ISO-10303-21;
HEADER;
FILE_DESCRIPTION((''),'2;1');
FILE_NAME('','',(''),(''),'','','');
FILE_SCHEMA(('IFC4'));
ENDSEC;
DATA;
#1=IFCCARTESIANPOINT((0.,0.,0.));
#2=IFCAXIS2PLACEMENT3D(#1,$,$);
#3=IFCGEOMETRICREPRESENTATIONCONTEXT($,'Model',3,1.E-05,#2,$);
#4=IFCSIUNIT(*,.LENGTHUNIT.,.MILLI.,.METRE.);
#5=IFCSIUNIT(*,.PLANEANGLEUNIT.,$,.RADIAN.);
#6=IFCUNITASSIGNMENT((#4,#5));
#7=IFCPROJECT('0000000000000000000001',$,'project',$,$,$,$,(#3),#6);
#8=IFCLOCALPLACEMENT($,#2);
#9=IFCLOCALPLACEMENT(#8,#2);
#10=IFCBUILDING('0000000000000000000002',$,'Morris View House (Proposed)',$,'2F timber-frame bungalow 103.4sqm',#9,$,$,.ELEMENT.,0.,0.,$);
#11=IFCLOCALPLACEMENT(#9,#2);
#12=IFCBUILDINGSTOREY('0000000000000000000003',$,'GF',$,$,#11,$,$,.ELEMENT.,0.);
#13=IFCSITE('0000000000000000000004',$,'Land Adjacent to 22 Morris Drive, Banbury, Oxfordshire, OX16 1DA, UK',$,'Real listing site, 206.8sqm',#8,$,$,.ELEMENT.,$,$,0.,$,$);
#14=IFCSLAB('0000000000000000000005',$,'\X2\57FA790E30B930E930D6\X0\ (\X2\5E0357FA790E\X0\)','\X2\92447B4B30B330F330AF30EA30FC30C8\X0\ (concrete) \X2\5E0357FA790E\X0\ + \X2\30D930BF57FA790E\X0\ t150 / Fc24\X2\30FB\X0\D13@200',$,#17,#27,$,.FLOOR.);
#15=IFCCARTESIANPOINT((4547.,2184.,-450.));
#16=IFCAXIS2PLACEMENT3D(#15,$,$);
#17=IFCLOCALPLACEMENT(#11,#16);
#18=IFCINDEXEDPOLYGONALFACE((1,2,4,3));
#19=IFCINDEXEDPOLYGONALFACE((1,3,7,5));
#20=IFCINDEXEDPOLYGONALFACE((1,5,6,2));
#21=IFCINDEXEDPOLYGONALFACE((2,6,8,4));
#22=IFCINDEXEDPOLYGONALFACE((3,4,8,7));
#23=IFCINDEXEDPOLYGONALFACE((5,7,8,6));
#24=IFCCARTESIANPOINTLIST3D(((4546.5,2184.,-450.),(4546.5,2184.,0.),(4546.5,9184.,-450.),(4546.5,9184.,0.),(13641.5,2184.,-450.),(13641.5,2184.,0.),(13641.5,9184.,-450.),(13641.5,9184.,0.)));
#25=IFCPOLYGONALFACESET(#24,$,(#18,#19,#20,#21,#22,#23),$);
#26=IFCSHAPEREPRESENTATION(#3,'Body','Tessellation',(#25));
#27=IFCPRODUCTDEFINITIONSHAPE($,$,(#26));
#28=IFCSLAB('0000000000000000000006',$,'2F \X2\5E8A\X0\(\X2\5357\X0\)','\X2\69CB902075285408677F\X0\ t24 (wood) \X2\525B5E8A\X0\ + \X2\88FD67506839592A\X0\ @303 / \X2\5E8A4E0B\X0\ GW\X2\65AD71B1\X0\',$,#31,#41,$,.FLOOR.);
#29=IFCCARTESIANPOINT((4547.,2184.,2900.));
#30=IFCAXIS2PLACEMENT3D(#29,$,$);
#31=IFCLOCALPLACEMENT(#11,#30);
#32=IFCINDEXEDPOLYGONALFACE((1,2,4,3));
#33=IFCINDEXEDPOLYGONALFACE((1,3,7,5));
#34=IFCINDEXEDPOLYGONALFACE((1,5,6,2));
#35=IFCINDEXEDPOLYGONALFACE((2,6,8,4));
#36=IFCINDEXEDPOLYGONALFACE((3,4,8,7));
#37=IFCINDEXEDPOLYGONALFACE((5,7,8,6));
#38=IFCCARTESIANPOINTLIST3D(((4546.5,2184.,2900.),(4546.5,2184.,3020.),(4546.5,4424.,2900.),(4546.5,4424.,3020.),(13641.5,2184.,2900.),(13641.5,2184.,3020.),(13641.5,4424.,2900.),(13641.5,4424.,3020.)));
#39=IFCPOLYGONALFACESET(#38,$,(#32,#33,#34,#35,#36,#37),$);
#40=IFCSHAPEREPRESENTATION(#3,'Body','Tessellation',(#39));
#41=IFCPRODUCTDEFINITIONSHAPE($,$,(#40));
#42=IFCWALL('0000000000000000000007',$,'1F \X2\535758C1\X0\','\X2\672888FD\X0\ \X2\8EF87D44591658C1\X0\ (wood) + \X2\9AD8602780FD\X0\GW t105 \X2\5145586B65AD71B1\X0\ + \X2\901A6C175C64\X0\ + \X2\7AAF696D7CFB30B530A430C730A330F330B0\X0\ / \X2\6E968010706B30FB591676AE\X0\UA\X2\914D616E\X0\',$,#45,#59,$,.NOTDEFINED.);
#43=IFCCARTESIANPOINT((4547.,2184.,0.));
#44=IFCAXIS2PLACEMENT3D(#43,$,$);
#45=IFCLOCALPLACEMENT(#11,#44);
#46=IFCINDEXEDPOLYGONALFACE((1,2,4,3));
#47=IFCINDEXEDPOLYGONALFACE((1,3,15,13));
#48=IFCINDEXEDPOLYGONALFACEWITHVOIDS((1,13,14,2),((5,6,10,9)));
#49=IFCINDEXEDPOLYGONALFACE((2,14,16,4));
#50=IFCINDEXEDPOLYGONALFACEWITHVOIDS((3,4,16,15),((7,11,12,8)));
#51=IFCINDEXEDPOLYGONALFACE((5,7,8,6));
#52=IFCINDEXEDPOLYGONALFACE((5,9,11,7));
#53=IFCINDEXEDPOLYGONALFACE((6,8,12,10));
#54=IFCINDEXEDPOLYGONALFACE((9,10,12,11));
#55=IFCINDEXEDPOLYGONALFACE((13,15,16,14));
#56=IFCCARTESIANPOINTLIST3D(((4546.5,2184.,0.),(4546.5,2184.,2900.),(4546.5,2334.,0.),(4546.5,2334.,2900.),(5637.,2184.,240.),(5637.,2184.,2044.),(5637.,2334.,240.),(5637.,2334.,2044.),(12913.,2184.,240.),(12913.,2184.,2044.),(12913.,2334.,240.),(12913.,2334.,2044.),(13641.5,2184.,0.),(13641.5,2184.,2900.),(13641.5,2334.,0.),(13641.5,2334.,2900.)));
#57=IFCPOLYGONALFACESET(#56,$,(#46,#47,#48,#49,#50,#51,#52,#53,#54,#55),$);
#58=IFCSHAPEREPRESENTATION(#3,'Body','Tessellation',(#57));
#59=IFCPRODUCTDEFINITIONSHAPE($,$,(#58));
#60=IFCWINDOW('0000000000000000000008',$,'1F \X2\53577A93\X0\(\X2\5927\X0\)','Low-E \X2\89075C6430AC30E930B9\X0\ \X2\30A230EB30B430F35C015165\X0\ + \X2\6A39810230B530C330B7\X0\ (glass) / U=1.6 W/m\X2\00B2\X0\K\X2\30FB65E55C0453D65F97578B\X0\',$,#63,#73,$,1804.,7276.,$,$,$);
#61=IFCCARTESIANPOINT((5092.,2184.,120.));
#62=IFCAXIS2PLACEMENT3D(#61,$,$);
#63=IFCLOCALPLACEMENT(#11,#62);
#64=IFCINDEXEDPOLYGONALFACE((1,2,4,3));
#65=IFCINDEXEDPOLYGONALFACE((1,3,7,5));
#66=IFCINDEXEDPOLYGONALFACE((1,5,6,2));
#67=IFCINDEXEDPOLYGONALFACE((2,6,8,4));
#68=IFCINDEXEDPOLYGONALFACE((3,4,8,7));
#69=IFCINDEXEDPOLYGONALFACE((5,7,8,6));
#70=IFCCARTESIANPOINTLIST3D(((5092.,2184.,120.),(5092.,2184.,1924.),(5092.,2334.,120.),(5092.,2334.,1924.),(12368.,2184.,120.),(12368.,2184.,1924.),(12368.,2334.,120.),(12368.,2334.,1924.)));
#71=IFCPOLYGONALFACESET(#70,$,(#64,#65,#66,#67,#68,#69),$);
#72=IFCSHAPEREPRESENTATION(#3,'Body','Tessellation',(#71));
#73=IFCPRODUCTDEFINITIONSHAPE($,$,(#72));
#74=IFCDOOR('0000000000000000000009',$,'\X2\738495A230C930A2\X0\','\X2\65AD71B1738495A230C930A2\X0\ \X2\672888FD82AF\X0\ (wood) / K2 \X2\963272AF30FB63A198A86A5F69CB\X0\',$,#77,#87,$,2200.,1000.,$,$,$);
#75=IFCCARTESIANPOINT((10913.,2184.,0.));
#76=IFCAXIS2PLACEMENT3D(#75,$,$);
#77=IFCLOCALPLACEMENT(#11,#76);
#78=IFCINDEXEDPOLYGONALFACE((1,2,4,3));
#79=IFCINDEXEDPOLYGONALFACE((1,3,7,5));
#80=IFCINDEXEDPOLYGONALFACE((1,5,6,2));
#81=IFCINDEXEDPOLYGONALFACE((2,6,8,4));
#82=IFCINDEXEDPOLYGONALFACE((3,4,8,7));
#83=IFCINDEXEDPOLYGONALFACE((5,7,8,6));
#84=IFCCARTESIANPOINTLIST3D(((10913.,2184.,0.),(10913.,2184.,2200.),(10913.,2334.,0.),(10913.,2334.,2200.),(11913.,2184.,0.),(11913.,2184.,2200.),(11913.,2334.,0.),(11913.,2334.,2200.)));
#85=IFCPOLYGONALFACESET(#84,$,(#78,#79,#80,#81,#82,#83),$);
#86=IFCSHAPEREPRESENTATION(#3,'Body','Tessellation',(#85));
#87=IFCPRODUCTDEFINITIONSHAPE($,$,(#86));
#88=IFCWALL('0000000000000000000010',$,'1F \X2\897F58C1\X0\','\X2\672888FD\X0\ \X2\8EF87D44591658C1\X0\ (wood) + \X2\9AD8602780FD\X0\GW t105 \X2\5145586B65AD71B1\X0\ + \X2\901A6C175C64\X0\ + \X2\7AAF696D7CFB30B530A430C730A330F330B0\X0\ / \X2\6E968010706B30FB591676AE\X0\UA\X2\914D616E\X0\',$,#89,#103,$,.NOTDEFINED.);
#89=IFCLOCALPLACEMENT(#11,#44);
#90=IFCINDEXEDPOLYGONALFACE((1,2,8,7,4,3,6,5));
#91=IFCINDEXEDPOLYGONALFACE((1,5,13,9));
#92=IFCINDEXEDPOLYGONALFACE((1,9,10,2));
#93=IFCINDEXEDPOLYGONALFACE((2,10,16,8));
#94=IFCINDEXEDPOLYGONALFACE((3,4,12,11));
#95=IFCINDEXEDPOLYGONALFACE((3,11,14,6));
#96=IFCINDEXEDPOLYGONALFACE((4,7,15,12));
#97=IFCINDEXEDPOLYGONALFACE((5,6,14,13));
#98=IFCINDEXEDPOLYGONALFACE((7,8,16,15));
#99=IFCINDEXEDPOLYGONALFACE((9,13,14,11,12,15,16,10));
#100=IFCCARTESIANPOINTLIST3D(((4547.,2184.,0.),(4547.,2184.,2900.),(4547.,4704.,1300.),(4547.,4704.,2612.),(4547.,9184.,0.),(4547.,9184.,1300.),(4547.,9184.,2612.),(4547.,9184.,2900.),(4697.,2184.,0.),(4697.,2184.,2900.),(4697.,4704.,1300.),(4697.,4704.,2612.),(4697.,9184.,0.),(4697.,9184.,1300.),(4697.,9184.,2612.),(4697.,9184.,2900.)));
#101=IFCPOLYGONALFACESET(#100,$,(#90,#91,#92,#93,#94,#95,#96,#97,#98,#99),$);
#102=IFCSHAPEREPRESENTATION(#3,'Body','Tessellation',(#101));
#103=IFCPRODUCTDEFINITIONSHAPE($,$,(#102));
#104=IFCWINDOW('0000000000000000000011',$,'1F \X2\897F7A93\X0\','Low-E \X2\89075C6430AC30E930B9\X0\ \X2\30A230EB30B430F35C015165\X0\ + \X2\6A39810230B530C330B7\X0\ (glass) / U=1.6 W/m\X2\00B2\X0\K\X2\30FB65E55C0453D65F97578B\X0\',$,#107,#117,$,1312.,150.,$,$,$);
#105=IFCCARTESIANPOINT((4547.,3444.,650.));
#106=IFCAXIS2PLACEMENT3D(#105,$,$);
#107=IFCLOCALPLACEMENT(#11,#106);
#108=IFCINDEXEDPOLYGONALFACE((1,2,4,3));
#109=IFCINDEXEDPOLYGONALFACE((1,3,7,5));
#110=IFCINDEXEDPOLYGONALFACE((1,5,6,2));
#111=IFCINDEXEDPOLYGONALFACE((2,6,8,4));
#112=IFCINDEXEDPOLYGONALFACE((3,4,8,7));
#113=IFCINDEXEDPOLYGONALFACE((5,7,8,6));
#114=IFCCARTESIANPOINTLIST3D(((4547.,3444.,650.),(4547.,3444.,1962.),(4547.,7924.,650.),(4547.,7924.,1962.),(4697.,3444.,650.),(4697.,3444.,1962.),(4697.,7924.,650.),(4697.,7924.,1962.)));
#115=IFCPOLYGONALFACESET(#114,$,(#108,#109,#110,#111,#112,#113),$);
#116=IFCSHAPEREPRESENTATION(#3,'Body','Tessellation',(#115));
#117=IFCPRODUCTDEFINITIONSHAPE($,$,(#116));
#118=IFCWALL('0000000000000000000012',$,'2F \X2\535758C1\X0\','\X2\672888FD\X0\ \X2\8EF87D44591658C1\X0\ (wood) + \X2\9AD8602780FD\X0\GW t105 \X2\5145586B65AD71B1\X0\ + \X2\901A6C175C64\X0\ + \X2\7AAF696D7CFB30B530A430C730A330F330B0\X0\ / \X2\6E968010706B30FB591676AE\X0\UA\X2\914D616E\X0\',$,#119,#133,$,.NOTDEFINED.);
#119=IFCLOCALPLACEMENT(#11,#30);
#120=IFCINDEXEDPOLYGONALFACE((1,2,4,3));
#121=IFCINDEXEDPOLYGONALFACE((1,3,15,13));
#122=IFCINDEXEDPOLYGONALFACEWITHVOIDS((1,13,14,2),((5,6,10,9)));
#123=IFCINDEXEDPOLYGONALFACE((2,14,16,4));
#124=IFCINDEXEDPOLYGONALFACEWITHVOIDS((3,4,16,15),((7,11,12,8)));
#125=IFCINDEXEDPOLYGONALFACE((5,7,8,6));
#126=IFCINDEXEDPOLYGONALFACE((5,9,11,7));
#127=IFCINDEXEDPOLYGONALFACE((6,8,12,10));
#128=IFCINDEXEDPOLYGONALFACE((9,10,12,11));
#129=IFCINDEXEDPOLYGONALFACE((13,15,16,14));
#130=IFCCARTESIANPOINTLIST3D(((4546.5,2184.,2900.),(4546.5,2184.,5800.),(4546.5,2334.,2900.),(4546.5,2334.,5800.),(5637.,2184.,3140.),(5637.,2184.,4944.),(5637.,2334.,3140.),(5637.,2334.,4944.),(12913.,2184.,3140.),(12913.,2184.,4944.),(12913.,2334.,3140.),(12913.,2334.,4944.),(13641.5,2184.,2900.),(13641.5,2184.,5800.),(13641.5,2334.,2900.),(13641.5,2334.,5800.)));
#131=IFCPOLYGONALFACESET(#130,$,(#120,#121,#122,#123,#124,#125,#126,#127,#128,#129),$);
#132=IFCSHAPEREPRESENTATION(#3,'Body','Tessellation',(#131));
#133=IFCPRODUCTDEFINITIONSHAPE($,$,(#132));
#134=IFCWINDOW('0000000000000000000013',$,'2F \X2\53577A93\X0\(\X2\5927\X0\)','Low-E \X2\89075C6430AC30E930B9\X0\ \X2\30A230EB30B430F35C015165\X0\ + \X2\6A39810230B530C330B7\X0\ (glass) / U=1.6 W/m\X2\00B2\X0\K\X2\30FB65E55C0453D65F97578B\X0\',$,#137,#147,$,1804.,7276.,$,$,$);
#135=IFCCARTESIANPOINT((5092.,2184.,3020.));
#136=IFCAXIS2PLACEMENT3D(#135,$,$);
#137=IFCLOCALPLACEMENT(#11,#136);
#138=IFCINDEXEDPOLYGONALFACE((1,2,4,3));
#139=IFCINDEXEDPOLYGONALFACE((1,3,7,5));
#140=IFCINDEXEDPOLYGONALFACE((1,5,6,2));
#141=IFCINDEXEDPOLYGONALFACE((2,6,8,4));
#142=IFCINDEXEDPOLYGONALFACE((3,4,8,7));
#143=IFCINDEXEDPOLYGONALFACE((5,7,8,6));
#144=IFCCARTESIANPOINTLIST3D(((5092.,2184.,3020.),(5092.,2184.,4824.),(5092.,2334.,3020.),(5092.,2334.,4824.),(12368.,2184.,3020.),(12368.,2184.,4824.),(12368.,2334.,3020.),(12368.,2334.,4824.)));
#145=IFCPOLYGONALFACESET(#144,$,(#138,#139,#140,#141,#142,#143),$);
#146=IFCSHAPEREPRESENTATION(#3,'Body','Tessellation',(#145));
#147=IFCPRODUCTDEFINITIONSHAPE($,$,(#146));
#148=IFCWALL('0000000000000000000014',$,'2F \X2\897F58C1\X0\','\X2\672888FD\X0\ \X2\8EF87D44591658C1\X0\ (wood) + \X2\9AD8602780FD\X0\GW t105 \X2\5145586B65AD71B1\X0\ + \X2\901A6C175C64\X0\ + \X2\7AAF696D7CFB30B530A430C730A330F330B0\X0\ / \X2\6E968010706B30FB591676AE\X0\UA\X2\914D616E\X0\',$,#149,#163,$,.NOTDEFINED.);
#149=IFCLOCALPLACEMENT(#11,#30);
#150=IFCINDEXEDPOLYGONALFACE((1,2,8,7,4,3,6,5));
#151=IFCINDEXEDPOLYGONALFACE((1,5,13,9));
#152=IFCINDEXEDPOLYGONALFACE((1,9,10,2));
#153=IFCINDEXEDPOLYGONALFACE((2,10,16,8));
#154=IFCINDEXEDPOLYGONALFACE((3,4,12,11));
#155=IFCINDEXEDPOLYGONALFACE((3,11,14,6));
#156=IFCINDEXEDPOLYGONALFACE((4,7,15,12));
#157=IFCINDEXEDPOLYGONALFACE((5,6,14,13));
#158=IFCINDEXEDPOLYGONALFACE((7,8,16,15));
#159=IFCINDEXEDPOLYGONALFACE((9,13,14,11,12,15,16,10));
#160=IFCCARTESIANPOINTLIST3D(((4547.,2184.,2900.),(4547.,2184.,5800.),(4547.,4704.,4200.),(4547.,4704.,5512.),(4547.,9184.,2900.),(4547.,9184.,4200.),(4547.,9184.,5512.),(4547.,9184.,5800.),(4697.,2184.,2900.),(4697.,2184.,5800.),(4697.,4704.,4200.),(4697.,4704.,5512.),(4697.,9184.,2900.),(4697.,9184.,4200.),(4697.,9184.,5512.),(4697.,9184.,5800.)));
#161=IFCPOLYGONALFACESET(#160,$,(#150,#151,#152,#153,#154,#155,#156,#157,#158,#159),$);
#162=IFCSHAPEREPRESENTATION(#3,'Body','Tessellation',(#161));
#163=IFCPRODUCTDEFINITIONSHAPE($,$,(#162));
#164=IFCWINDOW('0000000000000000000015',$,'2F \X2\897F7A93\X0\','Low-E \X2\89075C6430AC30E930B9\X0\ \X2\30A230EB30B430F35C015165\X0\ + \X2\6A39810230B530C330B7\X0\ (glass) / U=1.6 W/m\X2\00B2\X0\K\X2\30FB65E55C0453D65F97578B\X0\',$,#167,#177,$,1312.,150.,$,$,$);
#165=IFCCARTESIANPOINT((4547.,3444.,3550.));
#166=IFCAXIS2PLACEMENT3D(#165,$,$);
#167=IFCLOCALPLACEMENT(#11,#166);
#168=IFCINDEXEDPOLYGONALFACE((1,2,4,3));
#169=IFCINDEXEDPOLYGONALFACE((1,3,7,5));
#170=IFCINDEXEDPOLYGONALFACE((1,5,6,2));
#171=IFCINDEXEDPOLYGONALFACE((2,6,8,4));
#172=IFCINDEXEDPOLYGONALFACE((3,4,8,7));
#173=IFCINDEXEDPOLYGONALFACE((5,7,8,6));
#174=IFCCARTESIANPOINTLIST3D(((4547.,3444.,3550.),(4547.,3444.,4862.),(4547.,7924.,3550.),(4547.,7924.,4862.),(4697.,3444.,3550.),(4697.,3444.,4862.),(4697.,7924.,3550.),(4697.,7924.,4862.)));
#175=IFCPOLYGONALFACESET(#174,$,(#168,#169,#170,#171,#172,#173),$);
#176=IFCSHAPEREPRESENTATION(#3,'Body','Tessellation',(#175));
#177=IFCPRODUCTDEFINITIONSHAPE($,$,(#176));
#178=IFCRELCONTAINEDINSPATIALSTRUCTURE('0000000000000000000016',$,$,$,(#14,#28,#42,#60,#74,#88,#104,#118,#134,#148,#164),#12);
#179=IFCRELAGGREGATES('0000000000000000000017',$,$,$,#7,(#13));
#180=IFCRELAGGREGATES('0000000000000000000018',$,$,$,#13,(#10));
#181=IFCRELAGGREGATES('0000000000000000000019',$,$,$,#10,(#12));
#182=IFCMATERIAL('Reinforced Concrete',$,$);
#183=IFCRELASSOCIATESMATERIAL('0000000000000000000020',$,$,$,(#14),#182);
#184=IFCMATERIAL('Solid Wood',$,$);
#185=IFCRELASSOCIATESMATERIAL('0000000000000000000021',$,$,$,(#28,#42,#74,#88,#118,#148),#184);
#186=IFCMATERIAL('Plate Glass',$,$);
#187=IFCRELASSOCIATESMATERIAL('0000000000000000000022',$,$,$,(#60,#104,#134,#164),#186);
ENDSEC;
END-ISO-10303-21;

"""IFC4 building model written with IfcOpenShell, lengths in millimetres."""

from ifc_helpers import new_model, si_unit, frame, frame_2d, origin, place, context, project, spatial, rectangle, extrude, material, element, fill, save


model = new_model("IFC4")

# Units and contexts
model_context = context("Model", 3, precision=1e-05, world=origin())
ifc_project = project(units=[si_unit("LENGTHUNIT", "METRE", prefix="MILLI"), si_unit("PLANEANGLEUNIT", "RADIAN")], contexts=[model_context])

# Site, building, storey
site_placement = place(None, origin())
site = spatial("IfcSite", under=ifc_project, at=site_placement, Name="Land Adjacent to 22 Morris Drive, Banbury, Oxfordshire, OX16 1DA, UK", ObjectType="Real listing site, 206.8sqm", CompositionType="ELEMENT", RefElevation=0.0)
building_placement = place(site_placement, origin())
building = spatial("IfcBuilding", under=site, at=building_placement, Name="Morris View House (Proposed)", ObjectType="2F timber-frame bungalow 103.4sqm", CompositionType="ELEMENT", ElevationOfRefHeight=0.0, ElevationOfTerrain=0.0)
storey_placement = place(building_placement, origin())
storey = spatial("IfcBuildingStorey", under=building, at=storey_placement, Name="GF", CompositionType="ELEMENT", Elevation=0.0)

# Slabs
ifc_material_1 = material(Name="Reinforced Concrete")
slab_1_placement = place(storey_placement, frame((4547.0, 2184.0, -450.0)))
element("IfcSlab", 1, at=slab_1_placement, inside=storey, material=ifc_material_1, Name="基礎スラブ (布基礎)", Description="鉄筋コンクリート (concrete) 布基礎 + ベタ基礎 t150 / Fc24・D13@200", PredefinedType="FLOOR", context=model_context, shape_type="SweptSolid", body=[
    extrude(rectangle(XDim=9095.0, YDim=7000.0, at=frame_2d((4547.0, 3500.0))), frame((4547.0, 2184.0, -450.0)), (0.0, 0.0, 1.0), 450.0),
])
ifc_material_2 = material(Name="Solid Wood")
slab_2_placement = place(storey_placement, frame((4547.0, 2184.0, 2900.0)))
element("IfcSlab", 2, at=slab_2_placement, inside=storey, material=ifc_material_2, Name="2F 床(南)", Description="構造用合板 t24 (wood) 剛床 + 製材根太 @303 / 床下 GW断熱", PredefinedType="FLOOR", context=model_context, shape_type="SweptSolid", body=[
    extrude(rectangle(XDim=9095.0, YDim=2240.0, at=frame_2d((4547.0, 1120.0))), frame((4547.0, 2184.0, 2900.0)), (0.0, 0.0, 1.0), 120.0),
])

# Wall, openings, window, door
wall_1_placement = place(storey_placement, frame((4547.0, 2184.0, 0.0)))
wall_1 = element("IfcWall", 3, at=wall_1_placement, inside=storey, material=ifc_material_2, Name="1F 南壁", Description="木製 軸組外壁 (wood) + 高性能GW t105 充填断熱 + 通気層 + 窯業系サイディング / 準耐火・外皮UA配慮", PredefinedType="NOTDEFINED", context=model_context, shape_type="SweptSolid", body=[
    extrude(rectangle(XDim=9095.0, YDim=150.0, at=frame_2d((4547.0, 75.0))), frame((4547.0, 2184.0, 0.0)), (0.0, 0.0, 1.0), 2900.0),
])
opening_1_placement = place(storey_placement, frame((5092.0, 2184.0, 120.0)))
opening_1 = element("IfcOpeningElement", 4, at=opening_1_placement, cuts=wall_1, PredefinedType="NOTDEFINED", context=model_context, shape_type="SweptSolid", body=[
    extrude(rectangle(XDim=7276.0, YDim=150.0, at=frame_2d((3638.0, 75.0))), frame((5092.0, 2184.0, 120.0)), (0.0, 0.0, 1.0), 1804.0),
])
opening_2_placement = place(storey_placement, frame((10913.0, 2184.0, 0.0)))
opening_2 = element("IfcOpeningElement", 5, at=opening_2_placement, cuts=wall_1, PredefinedType="NOTDEFINED", context=model_context, shape_type="SweptSolid", body=[
    extrude(rectangle(XDim=1000.0, YDim=150.0, at=frame_2d((500.0, 75.0))), frame((10913.0, 2184.0, 0.0)), (0.0, 0.0, 1.0), 2200.0),
])
ifc_material_3 = material(Name="Plate Glass")
window_1_placement = place(storey_placement, frame((5092.0, 2184.0, 120.0)))
window_1 = element("IfcWindow", 6, at=window_1_placement, inside=storey, material=ifc_material_3, Name="1F 南窓(大)", Description="Low-E 複層ガラス アルゴン封入 + 樹脂サッシ (glass) / U=1.6 W/m²K・日射取得型", OverallHeight=1804.0, OverallWidth=7276.0, context=model_context, shape_type="SweptSolid", body=[
    extrude(rectangle(XDim=7276.0, YDim=150.0, at=frame_2d((3638.0, 75.0))), frame((5092.0, 2184.0, 120.0)), (0.0, 0.0, 1.0), 1804.0),
])
fill(opening_1, window_1)
door_placement = place(storey_placement, frame((10913.0, 2184.0, 0.0)))
door = element("IfcDoor", 7, at=door_placement, inside=storey, material=ifc_material_2, Name="玄関ドア", Description="断熱玄関ドア 木製芯 (wood) / K2 防犯・採風機構", OverallHeight=2200.0, OverallWidth=1000.0, context=model_context, shape_type="SweptSolid", body=[
    extrude(rectangle(XDim=1000.0, YDim=150.0, at=frame_2d((500.0, 75.0))), frame((10913.0, 2184.0, 0.0)), (0.0, 0.0, 1.0), 2200.0),
])
fill(opening_2, door)

# Walls, openings, windows
wall_2_placement = place(storey_placement, frame((4547.0, 2184.0, 0.0)))
wall_2 = element("IfcWall", 8, at=wall_2_placement, inside=storey, material=ifc_material_2, Name="1F 西壁", Description="木製 軸組外壁 (wood) + 高性能GW t105 充填断熱 + 通気層 + 窯業系サイディング / 準耐火・外皮UA配慮", PredefinedType="NOTDEFINED", context=model_context, shape_type="SweptSolid", body=[
    extrude(rectangle(XDim=150.0, YDim=7000.0, at=frame_2d((75.0, 3500.0))), frame((4547.0, 2184.0, 0.0)), (0.0, 0.0, 1.0), 2900.0),
])
opening_3_placement = place(storey_placement, frame((4547.0, 3444.0, 650.0)))
opening_3 = element("IfcOpeningElement", 9, at=opening_3_placement, cuts=wall_2, PredefinedType="NOTDEFINED", context=model_context, shape_type="SweptSolid", body=[
    extrude(rectangle(XDim=150.0, YDim=4480.0, at=frame_2d((75.0, 2240.0))), frame((4547.0, 3444.0, 650.0)), (0.0, 0.0, 1.0), 1312.0),
])
window_2_placement = place(storey_placement, frame((4547.0, 3444.0, 650.0)))
window_2 = element("IfcWindow", 10, at=window_2_placement, inside=storey, material=ifc_material_3, Name="1F 西窓", Description="Low-E 複層ガラス アルゴン封入 + 樹脂サッシ (glass) / U=1.6 W/m²K・日射取得型", OverallHeight=1312.0, OverallWidth=150.0, context=model_context, shape_type="SweptSolid", body=[
    extrude(rectangle(XDim=150.0, YDim=4480.0, at=frame_2d((75.0, 2240.0))), frame((4547.0, 3444.0, 650.0)), (0.0, 0.0, 1.0), 1312.0),
])
fill(opening_3, window_2)
wall_3_placement = place(storey_placement, frame((4547.0, 2184.0, 2900.0)))
wall_3 = element("IfcWall", 11, at=wall_3_placement, inside=storey, material=ifc_material_2, Name="2F 南壁", Description="木製 軸組外壁 (wood) + 高性能GW t105 充填断熱 + 通気層 + 窯業系サイディング / 準耐火・外皮UA配慮", PredefinedType="NOTDEFINED", context=model_context, shape_type="SweptSolid", body=[
    extrude(rectangle(XDim=9095.0, YDim=150.0, at=frame_2d((4547.0, 75.0))), frame((4547.0, 2184.0, 2900.0)), (0.0, 0.0, 1.0), 2900.0),
])
opening_4_placement = place(storey_placement, frame((5092.0, 2184.0, 3020.0)))
opening_4 = element("IfcOpeningElement", 12, at=opening_4_placement, cuts=wall_3, PredefinedType="NOTDEFINED", context=model_context, shape_type="SweptSolid", body=[
    extrude(rectangle(XDim=7276.0, YDim=150.0, at=frame_2d((3638.0, 75.0))), frame((5092.0, 2184.0, 3020.0)), (0.0, 0.0, 1.0), 1804.0),
])
window_3_placement = place(storey_placement, frame((5092.0, 2184.0, 3020.0)))
window_3 = element("IfcWindow", 13, at=window_3_placement, inside=storey, material=ifc_material_3, Name="2F 南窓(大)", Description="Low-E 複層ガラス アルゴン封入 + 樹脂サッシ (glass) / U=1.6 W/m²K・日射取得型", OverallHeight=1804.0, OverallWidth=7276.0, context=model_context, shape_type="SweptSolid", body=[
    extrude(rectangle(XDim=7276.0, YDim=150.0, at=frame_2d((3638.0, 75.0))), frame((5092.0, 2184.0, 3020.0)), (0.0, 0.0, 1.0), 1804.0),
])
fill(opening_4, window_3)
wall_4_placement = place(storey_placement, frame((4547.0, 2184.0, 2900.0)))
wall_4 = element("IfcWall", 14, at=wall_4_placement, inside=storey, material=ifc_material_2, Name="2F 西壁", Description="木製 軸組外壁 (wood) + 高性能GW t105 充填断熱 + 通気層 + 窯業系サイディング / 準耐火・外皮UA配慮", PredefinedType="NOTDEFINED", context=model_context, shape_type="SweptSolid", body=[
    extrude(rectangle(XDim=150.0, YDim=7000.0, at=frame_2d((75.0, 3500.0))), frame((4547.0, 2184.0, 2900.0)), (0.0, 0.0, 1.0), 2900.0),
])
opening_5_placement = place(storey_placement, frame((4547.0, 3444.0, 3550.0)))
opening_5 = element("IfcOpeningElement", 15, at=opening_5_placement, cuts=wall_4, PredefinedType="NOTDEFINED", context=model_context, shape_type="SweptSolid", body=[
    extrude(rectangle(XDim=150.0, YDim=4480.0, at=frame_2d((75.0, 2240.0))), frame((4547.0, 3444.0, 3550.0)), (0.0, 0.0, 1.0), 1312.0),
])
window_4_placement = place(storey_placement, frame((4547.0, 3444.0, 3550.0)))
window_4 = element("IfcWindow", 16, at=window_4_placement, inside=storey, material=ifc_material_3, Name="2F 西窓", Description="Low-E 複層ガラス アルゴン封入 + 樹脂サッシ (glass) / U=1.6 W/m²K・日射取得型", OverallHeight=1312.0, OverallWidth=150.0, context=model_context, shape_type="SweptSolid", body=[
    extrude(rectangle(XDim=150.0, YDim=4480.0, at=frame_2d((75.0, 2240.0))), frame((4547.0, 3444.0, 3550.0)), (0.0, 0.0, 1.0), 1312.0),
])
fill(opening_5, window_4)

save(model, "model.ifc")
